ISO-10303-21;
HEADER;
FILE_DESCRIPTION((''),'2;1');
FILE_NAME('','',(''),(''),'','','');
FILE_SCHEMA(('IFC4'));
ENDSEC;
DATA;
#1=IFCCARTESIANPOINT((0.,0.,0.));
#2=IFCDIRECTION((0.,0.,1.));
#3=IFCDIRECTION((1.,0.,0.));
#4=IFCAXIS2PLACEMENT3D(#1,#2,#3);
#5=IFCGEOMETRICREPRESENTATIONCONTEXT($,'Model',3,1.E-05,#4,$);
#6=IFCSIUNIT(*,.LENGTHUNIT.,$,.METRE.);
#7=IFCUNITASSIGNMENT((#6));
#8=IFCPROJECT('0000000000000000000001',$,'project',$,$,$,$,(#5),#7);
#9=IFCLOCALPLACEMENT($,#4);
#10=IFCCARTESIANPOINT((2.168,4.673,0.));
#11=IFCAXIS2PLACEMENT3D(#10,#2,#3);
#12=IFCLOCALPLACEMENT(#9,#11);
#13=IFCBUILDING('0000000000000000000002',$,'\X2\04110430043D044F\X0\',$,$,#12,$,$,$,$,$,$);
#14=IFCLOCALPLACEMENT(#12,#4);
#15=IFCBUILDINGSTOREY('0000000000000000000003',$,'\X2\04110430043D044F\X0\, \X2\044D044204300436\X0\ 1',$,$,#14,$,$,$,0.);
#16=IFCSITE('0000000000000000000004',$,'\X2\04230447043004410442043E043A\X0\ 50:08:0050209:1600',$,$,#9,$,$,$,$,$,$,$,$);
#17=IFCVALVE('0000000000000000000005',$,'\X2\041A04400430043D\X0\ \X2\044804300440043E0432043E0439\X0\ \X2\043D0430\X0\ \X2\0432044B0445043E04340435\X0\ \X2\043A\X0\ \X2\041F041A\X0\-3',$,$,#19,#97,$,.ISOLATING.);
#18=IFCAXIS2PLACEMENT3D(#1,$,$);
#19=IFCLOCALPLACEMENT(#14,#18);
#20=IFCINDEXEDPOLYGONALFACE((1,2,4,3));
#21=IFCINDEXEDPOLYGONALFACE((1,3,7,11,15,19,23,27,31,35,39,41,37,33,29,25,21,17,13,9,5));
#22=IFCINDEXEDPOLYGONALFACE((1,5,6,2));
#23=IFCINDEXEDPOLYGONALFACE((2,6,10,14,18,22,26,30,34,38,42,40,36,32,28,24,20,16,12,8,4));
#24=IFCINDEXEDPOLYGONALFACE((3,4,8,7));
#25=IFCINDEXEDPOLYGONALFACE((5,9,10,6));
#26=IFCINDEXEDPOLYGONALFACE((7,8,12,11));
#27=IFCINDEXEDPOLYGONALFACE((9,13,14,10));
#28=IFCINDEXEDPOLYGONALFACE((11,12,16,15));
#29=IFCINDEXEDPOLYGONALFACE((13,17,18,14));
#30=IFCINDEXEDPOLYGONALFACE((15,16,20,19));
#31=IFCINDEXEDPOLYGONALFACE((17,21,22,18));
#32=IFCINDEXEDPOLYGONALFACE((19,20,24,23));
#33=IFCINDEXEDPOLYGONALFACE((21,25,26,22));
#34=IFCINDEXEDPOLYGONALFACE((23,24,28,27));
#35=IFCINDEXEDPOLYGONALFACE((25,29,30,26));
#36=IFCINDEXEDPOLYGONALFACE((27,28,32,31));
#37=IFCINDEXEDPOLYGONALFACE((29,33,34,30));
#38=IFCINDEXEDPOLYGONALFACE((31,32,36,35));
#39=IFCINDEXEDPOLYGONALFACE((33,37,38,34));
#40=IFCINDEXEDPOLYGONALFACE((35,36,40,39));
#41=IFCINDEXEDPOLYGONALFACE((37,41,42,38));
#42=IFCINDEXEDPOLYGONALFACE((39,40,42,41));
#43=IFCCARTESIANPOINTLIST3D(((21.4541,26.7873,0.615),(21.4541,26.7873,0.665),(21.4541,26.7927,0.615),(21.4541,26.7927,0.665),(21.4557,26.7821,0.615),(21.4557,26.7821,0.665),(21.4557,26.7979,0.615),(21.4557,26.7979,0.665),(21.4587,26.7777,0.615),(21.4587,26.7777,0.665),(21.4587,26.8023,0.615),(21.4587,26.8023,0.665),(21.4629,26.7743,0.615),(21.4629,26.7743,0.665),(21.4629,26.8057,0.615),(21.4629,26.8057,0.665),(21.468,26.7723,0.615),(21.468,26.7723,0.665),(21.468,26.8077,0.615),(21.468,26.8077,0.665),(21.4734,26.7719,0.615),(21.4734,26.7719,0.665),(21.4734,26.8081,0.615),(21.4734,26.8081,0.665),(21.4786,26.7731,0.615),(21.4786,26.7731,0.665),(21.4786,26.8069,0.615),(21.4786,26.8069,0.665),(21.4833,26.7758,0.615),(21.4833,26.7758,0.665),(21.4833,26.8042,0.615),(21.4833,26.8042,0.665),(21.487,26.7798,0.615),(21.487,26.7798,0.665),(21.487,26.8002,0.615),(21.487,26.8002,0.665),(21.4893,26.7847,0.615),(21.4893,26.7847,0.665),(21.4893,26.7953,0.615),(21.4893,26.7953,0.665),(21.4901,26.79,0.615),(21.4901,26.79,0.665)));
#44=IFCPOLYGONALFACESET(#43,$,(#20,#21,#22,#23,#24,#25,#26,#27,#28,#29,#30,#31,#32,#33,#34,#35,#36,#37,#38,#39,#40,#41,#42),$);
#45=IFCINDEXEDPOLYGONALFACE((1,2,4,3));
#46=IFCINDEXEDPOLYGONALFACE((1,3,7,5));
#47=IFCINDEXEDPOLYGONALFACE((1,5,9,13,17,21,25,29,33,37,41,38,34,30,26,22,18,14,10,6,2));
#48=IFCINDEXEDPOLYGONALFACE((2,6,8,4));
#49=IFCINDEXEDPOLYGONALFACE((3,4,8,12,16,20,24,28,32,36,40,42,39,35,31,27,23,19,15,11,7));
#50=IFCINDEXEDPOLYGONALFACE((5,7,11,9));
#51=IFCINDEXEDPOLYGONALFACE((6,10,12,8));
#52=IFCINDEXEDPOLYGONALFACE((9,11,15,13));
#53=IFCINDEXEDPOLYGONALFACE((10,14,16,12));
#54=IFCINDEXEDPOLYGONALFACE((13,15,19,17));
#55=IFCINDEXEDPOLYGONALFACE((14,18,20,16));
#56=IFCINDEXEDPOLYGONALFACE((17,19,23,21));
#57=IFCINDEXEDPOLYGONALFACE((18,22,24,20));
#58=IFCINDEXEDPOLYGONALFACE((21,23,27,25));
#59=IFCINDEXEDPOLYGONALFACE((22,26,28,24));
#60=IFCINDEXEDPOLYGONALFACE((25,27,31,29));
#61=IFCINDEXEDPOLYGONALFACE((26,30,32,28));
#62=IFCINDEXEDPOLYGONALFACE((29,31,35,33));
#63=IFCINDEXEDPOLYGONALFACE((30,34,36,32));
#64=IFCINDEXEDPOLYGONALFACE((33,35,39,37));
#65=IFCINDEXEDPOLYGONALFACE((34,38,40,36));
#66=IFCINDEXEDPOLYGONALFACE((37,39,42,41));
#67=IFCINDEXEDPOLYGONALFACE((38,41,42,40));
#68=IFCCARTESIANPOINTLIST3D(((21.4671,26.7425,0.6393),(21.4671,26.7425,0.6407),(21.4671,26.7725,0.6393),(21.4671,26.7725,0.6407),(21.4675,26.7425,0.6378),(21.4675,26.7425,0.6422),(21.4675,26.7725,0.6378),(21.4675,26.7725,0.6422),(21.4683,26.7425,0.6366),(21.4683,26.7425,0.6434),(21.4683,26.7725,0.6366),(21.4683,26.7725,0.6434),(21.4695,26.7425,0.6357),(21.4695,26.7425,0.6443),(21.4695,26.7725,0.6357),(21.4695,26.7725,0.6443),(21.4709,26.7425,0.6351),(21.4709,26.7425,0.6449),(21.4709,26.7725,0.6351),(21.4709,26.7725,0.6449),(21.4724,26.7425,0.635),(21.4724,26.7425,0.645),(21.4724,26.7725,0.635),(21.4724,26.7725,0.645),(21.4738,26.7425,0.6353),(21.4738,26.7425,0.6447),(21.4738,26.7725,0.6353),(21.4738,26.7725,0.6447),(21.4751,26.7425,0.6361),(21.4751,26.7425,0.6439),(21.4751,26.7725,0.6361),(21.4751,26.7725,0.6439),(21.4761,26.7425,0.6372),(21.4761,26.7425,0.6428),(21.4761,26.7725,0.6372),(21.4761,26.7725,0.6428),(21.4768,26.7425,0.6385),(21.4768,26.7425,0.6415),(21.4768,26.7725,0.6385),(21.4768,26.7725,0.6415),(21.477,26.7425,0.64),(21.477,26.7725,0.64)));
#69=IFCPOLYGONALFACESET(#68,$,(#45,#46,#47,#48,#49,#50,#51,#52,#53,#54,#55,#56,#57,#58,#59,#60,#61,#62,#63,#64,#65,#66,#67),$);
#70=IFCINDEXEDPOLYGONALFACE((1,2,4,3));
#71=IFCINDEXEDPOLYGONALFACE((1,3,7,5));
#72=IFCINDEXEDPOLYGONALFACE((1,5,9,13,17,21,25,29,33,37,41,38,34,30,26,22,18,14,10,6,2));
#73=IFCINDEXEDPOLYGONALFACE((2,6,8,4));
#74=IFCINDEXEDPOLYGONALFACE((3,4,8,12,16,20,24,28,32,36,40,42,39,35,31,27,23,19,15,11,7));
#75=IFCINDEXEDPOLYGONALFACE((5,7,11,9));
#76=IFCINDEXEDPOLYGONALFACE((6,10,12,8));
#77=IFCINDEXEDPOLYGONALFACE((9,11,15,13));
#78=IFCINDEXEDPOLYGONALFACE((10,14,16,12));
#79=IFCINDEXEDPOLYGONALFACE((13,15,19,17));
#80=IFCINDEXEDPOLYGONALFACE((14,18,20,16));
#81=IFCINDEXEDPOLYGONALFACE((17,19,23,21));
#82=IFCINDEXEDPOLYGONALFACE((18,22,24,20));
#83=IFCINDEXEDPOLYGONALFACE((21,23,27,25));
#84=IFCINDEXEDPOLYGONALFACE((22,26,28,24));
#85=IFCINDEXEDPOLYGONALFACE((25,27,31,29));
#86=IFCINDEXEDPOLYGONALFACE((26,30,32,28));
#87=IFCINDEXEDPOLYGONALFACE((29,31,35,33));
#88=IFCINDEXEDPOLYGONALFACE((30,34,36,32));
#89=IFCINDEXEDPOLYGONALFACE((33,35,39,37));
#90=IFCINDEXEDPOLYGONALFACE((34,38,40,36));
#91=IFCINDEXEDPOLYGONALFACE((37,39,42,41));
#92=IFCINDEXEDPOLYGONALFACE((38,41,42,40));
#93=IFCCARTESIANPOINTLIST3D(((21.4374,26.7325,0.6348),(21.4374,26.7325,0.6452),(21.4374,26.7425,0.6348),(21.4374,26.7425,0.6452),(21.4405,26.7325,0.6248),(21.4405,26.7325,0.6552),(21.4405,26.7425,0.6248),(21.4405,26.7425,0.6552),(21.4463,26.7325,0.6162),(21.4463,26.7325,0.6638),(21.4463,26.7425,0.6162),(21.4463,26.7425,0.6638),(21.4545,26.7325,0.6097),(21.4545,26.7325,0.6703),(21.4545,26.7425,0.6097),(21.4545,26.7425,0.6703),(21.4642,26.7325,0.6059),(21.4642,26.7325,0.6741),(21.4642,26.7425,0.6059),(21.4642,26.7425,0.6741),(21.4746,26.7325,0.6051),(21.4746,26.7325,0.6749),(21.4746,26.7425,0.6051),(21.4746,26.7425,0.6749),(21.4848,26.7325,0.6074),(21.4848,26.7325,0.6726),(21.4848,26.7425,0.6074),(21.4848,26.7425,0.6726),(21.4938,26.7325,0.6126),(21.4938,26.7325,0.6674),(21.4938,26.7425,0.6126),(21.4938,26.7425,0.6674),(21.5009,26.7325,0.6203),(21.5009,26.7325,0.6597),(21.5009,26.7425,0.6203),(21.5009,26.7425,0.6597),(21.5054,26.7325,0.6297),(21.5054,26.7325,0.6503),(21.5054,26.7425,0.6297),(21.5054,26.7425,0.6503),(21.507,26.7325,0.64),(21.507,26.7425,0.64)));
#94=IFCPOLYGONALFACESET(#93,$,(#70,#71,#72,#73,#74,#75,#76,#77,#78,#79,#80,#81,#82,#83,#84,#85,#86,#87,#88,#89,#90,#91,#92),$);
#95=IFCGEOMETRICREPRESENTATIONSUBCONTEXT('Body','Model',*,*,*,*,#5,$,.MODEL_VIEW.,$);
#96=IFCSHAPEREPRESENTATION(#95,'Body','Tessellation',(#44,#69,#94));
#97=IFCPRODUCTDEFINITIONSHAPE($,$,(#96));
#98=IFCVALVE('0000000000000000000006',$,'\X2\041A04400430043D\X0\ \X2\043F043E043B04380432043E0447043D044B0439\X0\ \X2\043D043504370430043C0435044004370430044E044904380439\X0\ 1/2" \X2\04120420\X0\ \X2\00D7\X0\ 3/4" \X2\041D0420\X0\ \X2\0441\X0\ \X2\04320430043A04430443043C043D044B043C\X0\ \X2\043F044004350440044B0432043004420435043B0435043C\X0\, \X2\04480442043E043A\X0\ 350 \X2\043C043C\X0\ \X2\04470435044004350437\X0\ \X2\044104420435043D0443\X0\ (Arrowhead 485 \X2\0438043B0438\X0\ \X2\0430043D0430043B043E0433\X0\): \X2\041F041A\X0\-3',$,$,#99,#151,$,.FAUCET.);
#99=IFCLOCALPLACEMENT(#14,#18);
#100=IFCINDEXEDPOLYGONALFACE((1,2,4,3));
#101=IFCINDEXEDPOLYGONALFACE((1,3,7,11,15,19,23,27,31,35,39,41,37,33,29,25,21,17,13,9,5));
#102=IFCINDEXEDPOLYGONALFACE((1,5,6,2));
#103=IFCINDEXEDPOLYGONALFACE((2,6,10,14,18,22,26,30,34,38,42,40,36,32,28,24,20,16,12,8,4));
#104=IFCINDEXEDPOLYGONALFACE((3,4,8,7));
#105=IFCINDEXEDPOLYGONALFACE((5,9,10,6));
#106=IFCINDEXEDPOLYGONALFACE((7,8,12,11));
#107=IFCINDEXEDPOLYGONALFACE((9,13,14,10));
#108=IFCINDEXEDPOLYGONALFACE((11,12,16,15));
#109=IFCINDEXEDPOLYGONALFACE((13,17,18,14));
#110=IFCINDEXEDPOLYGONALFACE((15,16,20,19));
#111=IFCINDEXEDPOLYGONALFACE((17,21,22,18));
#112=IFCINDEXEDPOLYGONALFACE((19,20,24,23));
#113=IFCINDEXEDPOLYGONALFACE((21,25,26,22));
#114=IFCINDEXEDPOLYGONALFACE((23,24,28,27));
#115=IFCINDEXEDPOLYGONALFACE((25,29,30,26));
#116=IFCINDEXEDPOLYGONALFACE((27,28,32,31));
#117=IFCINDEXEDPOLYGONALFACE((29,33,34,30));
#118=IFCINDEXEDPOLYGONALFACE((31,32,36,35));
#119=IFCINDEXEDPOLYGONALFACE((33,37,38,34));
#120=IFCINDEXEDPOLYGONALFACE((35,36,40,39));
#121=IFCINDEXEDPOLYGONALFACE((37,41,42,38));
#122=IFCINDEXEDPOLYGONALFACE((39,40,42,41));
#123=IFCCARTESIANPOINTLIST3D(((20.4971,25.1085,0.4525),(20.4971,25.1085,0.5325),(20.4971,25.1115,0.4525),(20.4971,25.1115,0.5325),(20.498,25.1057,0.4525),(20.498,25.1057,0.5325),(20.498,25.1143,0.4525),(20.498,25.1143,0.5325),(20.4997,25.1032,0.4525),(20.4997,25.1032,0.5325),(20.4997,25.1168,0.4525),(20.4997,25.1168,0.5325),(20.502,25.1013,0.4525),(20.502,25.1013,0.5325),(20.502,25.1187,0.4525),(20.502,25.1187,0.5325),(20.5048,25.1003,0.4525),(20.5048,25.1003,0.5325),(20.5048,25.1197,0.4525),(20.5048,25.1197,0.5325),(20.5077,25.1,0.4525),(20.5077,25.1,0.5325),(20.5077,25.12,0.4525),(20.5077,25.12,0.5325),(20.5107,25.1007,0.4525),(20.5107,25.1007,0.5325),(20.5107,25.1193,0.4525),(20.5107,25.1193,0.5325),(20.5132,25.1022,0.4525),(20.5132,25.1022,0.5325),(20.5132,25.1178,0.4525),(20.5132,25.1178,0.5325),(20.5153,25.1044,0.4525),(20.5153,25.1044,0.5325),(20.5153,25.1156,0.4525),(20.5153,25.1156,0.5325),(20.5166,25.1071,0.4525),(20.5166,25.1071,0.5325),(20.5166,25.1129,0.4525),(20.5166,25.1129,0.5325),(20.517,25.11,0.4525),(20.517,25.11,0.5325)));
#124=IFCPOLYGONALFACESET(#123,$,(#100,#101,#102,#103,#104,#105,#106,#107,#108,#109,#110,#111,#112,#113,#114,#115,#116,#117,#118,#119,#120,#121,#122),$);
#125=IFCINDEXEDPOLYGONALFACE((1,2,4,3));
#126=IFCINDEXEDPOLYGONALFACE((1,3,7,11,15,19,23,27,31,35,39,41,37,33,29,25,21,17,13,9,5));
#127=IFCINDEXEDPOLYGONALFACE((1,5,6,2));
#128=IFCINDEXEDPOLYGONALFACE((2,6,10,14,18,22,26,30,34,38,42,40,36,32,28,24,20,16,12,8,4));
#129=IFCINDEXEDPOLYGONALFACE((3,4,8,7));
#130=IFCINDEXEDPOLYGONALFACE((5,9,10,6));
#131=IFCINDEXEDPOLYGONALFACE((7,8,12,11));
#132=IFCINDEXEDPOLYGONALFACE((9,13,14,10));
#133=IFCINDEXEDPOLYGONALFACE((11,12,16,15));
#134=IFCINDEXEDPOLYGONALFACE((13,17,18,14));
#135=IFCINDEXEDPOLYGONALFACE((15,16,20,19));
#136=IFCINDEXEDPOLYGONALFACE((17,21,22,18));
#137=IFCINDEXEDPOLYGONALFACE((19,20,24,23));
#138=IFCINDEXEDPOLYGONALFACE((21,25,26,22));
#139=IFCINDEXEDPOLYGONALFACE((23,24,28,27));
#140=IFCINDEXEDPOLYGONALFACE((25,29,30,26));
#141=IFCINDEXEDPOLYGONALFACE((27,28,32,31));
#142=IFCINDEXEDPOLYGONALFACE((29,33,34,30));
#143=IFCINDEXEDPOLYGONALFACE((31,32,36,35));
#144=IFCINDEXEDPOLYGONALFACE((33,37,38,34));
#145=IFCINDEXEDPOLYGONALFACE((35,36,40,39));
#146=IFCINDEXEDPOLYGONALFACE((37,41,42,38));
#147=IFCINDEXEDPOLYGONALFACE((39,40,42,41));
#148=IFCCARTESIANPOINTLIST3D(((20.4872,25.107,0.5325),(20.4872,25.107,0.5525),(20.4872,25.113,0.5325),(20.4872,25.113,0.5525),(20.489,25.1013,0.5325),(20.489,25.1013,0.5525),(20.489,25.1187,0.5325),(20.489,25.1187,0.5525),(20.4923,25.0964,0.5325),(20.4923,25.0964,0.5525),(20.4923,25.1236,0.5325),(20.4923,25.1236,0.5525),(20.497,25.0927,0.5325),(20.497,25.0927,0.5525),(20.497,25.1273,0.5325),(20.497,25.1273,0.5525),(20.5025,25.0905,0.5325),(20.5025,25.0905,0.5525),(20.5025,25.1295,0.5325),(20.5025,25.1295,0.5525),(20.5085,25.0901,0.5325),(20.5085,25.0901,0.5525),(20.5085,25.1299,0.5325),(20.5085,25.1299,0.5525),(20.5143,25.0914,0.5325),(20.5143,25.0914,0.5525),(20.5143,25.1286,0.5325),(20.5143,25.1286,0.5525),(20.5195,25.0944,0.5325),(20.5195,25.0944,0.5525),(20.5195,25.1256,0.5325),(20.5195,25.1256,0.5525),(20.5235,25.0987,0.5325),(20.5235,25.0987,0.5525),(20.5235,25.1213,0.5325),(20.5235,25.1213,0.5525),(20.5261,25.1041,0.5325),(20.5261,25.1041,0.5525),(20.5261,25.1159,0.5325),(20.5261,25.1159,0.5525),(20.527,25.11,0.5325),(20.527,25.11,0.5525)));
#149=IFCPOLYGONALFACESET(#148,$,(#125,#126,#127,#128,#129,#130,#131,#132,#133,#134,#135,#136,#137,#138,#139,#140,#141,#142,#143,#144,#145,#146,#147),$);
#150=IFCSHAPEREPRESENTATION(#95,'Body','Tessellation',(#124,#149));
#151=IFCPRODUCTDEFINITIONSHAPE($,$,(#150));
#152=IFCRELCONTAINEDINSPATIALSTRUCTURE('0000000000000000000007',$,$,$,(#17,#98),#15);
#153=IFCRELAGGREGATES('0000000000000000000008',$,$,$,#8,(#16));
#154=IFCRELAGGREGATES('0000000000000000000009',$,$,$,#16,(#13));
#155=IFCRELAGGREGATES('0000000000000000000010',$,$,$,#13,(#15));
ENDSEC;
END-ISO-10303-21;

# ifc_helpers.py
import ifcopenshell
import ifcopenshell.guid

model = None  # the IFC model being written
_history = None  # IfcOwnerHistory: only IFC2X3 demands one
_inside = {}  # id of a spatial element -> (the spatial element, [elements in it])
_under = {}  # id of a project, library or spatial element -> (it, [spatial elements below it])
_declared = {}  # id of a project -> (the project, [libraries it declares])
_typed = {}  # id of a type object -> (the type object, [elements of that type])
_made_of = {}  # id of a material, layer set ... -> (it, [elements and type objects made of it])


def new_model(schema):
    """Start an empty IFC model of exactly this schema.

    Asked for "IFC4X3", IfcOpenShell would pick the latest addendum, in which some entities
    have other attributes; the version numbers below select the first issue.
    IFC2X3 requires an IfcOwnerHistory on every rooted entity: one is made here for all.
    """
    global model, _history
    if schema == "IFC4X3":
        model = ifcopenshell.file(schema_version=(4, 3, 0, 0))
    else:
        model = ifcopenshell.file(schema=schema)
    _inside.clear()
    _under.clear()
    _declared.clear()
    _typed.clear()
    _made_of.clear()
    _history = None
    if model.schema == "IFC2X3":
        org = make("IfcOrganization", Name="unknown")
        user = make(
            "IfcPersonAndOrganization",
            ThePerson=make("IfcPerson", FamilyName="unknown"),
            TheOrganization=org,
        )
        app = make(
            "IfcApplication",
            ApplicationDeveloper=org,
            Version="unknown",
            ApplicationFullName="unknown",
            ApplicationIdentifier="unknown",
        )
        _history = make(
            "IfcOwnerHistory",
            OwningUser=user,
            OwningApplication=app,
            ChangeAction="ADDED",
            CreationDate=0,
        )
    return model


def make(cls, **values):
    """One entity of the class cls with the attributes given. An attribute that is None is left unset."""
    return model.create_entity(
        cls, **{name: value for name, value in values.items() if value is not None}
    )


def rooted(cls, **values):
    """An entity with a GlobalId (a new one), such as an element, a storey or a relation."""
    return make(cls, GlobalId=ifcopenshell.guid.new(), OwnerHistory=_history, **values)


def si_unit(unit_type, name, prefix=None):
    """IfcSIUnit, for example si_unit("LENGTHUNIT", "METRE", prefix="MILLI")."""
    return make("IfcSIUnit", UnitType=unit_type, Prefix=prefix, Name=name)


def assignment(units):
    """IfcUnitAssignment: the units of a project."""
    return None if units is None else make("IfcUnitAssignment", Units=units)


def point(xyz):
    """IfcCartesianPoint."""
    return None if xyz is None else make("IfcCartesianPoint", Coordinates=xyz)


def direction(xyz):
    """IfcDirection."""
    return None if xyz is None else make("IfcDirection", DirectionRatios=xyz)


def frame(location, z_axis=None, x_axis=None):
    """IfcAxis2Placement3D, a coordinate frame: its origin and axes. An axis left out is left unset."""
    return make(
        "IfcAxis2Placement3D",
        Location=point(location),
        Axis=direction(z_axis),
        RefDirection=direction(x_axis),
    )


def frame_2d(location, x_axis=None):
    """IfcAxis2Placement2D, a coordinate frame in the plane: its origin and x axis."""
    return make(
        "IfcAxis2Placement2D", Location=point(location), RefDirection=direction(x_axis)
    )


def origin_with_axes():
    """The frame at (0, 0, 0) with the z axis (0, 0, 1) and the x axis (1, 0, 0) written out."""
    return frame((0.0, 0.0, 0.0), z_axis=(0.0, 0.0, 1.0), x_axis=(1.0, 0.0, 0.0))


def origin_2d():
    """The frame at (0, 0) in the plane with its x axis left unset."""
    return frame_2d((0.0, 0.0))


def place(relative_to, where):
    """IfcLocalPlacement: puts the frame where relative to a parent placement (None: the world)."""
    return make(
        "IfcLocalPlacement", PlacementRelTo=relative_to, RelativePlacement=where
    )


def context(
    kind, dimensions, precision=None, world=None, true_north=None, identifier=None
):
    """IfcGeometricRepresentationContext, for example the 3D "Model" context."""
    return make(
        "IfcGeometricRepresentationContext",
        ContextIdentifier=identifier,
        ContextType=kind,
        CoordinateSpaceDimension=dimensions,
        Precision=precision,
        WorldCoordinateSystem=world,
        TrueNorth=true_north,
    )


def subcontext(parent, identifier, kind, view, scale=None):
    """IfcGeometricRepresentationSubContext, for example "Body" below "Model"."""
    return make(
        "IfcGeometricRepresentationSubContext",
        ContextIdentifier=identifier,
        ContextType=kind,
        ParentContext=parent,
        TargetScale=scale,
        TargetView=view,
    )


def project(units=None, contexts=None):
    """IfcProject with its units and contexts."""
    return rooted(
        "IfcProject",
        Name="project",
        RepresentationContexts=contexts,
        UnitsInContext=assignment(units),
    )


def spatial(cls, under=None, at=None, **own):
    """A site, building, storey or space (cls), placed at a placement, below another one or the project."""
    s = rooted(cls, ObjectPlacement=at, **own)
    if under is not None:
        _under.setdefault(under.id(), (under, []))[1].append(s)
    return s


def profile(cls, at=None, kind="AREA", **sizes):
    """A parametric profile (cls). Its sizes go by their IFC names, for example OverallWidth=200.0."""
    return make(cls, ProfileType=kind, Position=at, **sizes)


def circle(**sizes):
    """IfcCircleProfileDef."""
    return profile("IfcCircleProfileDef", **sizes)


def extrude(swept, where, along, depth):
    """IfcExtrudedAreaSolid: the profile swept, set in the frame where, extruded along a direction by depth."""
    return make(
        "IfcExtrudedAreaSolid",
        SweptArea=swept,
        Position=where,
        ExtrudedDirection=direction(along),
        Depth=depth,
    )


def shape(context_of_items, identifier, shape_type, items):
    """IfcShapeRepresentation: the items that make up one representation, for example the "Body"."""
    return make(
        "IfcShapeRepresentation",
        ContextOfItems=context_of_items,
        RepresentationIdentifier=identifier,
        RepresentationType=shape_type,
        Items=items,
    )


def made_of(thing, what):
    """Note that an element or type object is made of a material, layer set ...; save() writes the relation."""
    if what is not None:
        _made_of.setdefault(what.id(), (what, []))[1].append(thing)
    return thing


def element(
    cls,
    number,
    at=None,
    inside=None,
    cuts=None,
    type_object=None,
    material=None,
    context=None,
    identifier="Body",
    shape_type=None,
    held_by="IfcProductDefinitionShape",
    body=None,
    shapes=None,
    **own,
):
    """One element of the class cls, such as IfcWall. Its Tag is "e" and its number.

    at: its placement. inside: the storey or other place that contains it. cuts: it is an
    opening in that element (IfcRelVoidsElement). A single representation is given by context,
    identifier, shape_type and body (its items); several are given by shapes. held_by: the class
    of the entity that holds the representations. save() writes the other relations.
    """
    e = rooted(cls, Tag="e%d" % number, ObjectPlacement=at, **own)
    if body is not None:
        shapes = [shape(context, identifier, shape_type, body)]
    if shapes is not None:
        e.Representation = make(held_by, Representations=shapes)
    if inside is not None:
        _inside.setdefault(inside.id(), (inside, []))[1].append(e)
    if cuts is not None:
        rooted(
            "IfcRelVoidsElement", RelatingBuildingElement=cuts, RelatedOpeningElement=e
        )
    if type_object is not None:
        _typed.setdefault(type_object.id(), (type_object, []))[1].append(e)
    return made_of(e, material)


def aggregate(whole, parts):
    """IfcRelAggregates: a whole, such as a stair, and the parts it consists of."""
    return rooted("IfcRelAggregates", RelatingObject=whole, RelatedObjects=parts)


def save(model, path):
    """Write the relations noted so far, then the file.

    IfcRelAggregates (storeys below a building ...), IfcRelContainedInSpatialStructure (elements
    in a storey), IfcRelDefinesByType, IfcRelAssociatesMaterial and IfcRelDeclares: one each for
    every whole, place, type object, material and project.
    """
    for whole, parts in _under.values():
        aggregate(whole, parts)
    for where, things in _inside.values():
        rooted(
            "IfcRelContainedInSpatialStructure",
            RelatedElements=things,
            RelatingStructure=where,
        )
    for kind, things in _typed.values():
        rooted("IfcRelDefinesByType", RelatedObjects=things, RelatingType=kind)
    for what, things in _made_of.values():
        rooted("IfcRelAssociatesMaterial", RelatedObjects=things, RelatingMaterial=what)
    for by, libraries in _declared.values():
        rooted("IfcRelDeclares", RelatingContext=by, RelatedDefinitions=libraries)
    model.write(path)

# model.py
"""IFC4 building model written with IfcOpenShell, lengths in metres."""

from ifc_helpers import new_model, si_unit, frame, origin_with_axes, origin_2d, place, context, subcontext, project, spatial, circle, extrude, element, save


model = new_model("IFC4")

# Units and contexts
model_context = context("Model", 3, precision=1e-05, world=origin_with_axes())
body_context = subcontext(model_context, "Body", "Model", "MODEL_VIEW")
ifc_project = project(units=[si_unit("LENGTHUNIT", "METRE")], contexts=[model_context])

# Site, building, storey
site_placement = place(None, origin_with_axes())
site = spatial("IfcSite", under=ifc_project, at=site_placement, Name="Участок 50:08:0050209:1600")
building_placement = place(site_placement, frame((2.168, 4.673, 0.0), z_axis=(0.0, 0.0, 1.0), x_axis=(1.0, 0.0, 0.0)))
building = spatial("IfcBuilding", under=site, at=building_placement, Name="Баня")
storey_placement = place(building_placement, origin_with_axes())
storey = spatial("IfcBuildingStorey", under=building, at=storey_placement, Name="Баня, этаж 1", Elevation=0.0)

# Valves
valve_1_placement = place(storey_placement, origin_with_axes())
element("IfcValve", 1, at=valve_1_placement, inside=storey, Name="Кран шаровой на выходе к ПК-3", PredefinedType="ISOLATING", context=body_context, shape_type="SweptSolid", body=[
    extrude(circle(Radius=0.0181, at=origin_2d()), frame((21.472, 26.79, 0.615), z_axis=(0.0, 0.0, 1.0), x_axis=(1.0, 0.0, 0.0)), (0.0, 0.0, 1.0), 0.05),
    extrude(circle(Radius=0.005, at=origin_2d()), frame((21.472, 26.7725, 0.64), z_axis=(0.0, -1.0, 0.0), x_axis=(1.0, 0.0, 0.0)), (0.0, 0.0, 1.0), 0.03),
    extrude(circle(Radius=0.035, at=origin_2d()), frame((21.472, 26.7425, 0.64), z_axis=(0.0, -1.0, 0.0), x_axis=(1.0, 0.0, 0.0)), (0.0, 0.0, 1.0), 0.01),
])
valve_2_placement = place(storey_placement, origin_with_axes())
element("IfcValve", 2, at=valve_2_placement, inside=storey, Name="Кран поливочный незамерзающий 1/2\" ВР × 3/4\" НР с вакуумным прерывателем, шток 350 мм через стену (Arrowhead 485 или аналог): ПК-3", PredefinedType="FAUCET", context=body_context, shape_type="SweptSolid", body=[
    extrude(circle(Radius=0.01, at=origin_2d()), frame((20.507, 25.11, 0.4525), z_axis=(0.0, 0.0, 1.0), x_axis=(1.0, 0.0, 0.0)), (0.0, 0.0, 1.0), 0.08),
    extrude(circle(Radius=0.02, at=origin_2d()), frame((20.507, 25.11, 0.5325), z_axis=(0.0, 0.0, 1.0), x_axis=(1.0, 0.0, 0.0)), (0.0, 0.0, 1.0), 0.02),
])

save(model, "model.ifc")
